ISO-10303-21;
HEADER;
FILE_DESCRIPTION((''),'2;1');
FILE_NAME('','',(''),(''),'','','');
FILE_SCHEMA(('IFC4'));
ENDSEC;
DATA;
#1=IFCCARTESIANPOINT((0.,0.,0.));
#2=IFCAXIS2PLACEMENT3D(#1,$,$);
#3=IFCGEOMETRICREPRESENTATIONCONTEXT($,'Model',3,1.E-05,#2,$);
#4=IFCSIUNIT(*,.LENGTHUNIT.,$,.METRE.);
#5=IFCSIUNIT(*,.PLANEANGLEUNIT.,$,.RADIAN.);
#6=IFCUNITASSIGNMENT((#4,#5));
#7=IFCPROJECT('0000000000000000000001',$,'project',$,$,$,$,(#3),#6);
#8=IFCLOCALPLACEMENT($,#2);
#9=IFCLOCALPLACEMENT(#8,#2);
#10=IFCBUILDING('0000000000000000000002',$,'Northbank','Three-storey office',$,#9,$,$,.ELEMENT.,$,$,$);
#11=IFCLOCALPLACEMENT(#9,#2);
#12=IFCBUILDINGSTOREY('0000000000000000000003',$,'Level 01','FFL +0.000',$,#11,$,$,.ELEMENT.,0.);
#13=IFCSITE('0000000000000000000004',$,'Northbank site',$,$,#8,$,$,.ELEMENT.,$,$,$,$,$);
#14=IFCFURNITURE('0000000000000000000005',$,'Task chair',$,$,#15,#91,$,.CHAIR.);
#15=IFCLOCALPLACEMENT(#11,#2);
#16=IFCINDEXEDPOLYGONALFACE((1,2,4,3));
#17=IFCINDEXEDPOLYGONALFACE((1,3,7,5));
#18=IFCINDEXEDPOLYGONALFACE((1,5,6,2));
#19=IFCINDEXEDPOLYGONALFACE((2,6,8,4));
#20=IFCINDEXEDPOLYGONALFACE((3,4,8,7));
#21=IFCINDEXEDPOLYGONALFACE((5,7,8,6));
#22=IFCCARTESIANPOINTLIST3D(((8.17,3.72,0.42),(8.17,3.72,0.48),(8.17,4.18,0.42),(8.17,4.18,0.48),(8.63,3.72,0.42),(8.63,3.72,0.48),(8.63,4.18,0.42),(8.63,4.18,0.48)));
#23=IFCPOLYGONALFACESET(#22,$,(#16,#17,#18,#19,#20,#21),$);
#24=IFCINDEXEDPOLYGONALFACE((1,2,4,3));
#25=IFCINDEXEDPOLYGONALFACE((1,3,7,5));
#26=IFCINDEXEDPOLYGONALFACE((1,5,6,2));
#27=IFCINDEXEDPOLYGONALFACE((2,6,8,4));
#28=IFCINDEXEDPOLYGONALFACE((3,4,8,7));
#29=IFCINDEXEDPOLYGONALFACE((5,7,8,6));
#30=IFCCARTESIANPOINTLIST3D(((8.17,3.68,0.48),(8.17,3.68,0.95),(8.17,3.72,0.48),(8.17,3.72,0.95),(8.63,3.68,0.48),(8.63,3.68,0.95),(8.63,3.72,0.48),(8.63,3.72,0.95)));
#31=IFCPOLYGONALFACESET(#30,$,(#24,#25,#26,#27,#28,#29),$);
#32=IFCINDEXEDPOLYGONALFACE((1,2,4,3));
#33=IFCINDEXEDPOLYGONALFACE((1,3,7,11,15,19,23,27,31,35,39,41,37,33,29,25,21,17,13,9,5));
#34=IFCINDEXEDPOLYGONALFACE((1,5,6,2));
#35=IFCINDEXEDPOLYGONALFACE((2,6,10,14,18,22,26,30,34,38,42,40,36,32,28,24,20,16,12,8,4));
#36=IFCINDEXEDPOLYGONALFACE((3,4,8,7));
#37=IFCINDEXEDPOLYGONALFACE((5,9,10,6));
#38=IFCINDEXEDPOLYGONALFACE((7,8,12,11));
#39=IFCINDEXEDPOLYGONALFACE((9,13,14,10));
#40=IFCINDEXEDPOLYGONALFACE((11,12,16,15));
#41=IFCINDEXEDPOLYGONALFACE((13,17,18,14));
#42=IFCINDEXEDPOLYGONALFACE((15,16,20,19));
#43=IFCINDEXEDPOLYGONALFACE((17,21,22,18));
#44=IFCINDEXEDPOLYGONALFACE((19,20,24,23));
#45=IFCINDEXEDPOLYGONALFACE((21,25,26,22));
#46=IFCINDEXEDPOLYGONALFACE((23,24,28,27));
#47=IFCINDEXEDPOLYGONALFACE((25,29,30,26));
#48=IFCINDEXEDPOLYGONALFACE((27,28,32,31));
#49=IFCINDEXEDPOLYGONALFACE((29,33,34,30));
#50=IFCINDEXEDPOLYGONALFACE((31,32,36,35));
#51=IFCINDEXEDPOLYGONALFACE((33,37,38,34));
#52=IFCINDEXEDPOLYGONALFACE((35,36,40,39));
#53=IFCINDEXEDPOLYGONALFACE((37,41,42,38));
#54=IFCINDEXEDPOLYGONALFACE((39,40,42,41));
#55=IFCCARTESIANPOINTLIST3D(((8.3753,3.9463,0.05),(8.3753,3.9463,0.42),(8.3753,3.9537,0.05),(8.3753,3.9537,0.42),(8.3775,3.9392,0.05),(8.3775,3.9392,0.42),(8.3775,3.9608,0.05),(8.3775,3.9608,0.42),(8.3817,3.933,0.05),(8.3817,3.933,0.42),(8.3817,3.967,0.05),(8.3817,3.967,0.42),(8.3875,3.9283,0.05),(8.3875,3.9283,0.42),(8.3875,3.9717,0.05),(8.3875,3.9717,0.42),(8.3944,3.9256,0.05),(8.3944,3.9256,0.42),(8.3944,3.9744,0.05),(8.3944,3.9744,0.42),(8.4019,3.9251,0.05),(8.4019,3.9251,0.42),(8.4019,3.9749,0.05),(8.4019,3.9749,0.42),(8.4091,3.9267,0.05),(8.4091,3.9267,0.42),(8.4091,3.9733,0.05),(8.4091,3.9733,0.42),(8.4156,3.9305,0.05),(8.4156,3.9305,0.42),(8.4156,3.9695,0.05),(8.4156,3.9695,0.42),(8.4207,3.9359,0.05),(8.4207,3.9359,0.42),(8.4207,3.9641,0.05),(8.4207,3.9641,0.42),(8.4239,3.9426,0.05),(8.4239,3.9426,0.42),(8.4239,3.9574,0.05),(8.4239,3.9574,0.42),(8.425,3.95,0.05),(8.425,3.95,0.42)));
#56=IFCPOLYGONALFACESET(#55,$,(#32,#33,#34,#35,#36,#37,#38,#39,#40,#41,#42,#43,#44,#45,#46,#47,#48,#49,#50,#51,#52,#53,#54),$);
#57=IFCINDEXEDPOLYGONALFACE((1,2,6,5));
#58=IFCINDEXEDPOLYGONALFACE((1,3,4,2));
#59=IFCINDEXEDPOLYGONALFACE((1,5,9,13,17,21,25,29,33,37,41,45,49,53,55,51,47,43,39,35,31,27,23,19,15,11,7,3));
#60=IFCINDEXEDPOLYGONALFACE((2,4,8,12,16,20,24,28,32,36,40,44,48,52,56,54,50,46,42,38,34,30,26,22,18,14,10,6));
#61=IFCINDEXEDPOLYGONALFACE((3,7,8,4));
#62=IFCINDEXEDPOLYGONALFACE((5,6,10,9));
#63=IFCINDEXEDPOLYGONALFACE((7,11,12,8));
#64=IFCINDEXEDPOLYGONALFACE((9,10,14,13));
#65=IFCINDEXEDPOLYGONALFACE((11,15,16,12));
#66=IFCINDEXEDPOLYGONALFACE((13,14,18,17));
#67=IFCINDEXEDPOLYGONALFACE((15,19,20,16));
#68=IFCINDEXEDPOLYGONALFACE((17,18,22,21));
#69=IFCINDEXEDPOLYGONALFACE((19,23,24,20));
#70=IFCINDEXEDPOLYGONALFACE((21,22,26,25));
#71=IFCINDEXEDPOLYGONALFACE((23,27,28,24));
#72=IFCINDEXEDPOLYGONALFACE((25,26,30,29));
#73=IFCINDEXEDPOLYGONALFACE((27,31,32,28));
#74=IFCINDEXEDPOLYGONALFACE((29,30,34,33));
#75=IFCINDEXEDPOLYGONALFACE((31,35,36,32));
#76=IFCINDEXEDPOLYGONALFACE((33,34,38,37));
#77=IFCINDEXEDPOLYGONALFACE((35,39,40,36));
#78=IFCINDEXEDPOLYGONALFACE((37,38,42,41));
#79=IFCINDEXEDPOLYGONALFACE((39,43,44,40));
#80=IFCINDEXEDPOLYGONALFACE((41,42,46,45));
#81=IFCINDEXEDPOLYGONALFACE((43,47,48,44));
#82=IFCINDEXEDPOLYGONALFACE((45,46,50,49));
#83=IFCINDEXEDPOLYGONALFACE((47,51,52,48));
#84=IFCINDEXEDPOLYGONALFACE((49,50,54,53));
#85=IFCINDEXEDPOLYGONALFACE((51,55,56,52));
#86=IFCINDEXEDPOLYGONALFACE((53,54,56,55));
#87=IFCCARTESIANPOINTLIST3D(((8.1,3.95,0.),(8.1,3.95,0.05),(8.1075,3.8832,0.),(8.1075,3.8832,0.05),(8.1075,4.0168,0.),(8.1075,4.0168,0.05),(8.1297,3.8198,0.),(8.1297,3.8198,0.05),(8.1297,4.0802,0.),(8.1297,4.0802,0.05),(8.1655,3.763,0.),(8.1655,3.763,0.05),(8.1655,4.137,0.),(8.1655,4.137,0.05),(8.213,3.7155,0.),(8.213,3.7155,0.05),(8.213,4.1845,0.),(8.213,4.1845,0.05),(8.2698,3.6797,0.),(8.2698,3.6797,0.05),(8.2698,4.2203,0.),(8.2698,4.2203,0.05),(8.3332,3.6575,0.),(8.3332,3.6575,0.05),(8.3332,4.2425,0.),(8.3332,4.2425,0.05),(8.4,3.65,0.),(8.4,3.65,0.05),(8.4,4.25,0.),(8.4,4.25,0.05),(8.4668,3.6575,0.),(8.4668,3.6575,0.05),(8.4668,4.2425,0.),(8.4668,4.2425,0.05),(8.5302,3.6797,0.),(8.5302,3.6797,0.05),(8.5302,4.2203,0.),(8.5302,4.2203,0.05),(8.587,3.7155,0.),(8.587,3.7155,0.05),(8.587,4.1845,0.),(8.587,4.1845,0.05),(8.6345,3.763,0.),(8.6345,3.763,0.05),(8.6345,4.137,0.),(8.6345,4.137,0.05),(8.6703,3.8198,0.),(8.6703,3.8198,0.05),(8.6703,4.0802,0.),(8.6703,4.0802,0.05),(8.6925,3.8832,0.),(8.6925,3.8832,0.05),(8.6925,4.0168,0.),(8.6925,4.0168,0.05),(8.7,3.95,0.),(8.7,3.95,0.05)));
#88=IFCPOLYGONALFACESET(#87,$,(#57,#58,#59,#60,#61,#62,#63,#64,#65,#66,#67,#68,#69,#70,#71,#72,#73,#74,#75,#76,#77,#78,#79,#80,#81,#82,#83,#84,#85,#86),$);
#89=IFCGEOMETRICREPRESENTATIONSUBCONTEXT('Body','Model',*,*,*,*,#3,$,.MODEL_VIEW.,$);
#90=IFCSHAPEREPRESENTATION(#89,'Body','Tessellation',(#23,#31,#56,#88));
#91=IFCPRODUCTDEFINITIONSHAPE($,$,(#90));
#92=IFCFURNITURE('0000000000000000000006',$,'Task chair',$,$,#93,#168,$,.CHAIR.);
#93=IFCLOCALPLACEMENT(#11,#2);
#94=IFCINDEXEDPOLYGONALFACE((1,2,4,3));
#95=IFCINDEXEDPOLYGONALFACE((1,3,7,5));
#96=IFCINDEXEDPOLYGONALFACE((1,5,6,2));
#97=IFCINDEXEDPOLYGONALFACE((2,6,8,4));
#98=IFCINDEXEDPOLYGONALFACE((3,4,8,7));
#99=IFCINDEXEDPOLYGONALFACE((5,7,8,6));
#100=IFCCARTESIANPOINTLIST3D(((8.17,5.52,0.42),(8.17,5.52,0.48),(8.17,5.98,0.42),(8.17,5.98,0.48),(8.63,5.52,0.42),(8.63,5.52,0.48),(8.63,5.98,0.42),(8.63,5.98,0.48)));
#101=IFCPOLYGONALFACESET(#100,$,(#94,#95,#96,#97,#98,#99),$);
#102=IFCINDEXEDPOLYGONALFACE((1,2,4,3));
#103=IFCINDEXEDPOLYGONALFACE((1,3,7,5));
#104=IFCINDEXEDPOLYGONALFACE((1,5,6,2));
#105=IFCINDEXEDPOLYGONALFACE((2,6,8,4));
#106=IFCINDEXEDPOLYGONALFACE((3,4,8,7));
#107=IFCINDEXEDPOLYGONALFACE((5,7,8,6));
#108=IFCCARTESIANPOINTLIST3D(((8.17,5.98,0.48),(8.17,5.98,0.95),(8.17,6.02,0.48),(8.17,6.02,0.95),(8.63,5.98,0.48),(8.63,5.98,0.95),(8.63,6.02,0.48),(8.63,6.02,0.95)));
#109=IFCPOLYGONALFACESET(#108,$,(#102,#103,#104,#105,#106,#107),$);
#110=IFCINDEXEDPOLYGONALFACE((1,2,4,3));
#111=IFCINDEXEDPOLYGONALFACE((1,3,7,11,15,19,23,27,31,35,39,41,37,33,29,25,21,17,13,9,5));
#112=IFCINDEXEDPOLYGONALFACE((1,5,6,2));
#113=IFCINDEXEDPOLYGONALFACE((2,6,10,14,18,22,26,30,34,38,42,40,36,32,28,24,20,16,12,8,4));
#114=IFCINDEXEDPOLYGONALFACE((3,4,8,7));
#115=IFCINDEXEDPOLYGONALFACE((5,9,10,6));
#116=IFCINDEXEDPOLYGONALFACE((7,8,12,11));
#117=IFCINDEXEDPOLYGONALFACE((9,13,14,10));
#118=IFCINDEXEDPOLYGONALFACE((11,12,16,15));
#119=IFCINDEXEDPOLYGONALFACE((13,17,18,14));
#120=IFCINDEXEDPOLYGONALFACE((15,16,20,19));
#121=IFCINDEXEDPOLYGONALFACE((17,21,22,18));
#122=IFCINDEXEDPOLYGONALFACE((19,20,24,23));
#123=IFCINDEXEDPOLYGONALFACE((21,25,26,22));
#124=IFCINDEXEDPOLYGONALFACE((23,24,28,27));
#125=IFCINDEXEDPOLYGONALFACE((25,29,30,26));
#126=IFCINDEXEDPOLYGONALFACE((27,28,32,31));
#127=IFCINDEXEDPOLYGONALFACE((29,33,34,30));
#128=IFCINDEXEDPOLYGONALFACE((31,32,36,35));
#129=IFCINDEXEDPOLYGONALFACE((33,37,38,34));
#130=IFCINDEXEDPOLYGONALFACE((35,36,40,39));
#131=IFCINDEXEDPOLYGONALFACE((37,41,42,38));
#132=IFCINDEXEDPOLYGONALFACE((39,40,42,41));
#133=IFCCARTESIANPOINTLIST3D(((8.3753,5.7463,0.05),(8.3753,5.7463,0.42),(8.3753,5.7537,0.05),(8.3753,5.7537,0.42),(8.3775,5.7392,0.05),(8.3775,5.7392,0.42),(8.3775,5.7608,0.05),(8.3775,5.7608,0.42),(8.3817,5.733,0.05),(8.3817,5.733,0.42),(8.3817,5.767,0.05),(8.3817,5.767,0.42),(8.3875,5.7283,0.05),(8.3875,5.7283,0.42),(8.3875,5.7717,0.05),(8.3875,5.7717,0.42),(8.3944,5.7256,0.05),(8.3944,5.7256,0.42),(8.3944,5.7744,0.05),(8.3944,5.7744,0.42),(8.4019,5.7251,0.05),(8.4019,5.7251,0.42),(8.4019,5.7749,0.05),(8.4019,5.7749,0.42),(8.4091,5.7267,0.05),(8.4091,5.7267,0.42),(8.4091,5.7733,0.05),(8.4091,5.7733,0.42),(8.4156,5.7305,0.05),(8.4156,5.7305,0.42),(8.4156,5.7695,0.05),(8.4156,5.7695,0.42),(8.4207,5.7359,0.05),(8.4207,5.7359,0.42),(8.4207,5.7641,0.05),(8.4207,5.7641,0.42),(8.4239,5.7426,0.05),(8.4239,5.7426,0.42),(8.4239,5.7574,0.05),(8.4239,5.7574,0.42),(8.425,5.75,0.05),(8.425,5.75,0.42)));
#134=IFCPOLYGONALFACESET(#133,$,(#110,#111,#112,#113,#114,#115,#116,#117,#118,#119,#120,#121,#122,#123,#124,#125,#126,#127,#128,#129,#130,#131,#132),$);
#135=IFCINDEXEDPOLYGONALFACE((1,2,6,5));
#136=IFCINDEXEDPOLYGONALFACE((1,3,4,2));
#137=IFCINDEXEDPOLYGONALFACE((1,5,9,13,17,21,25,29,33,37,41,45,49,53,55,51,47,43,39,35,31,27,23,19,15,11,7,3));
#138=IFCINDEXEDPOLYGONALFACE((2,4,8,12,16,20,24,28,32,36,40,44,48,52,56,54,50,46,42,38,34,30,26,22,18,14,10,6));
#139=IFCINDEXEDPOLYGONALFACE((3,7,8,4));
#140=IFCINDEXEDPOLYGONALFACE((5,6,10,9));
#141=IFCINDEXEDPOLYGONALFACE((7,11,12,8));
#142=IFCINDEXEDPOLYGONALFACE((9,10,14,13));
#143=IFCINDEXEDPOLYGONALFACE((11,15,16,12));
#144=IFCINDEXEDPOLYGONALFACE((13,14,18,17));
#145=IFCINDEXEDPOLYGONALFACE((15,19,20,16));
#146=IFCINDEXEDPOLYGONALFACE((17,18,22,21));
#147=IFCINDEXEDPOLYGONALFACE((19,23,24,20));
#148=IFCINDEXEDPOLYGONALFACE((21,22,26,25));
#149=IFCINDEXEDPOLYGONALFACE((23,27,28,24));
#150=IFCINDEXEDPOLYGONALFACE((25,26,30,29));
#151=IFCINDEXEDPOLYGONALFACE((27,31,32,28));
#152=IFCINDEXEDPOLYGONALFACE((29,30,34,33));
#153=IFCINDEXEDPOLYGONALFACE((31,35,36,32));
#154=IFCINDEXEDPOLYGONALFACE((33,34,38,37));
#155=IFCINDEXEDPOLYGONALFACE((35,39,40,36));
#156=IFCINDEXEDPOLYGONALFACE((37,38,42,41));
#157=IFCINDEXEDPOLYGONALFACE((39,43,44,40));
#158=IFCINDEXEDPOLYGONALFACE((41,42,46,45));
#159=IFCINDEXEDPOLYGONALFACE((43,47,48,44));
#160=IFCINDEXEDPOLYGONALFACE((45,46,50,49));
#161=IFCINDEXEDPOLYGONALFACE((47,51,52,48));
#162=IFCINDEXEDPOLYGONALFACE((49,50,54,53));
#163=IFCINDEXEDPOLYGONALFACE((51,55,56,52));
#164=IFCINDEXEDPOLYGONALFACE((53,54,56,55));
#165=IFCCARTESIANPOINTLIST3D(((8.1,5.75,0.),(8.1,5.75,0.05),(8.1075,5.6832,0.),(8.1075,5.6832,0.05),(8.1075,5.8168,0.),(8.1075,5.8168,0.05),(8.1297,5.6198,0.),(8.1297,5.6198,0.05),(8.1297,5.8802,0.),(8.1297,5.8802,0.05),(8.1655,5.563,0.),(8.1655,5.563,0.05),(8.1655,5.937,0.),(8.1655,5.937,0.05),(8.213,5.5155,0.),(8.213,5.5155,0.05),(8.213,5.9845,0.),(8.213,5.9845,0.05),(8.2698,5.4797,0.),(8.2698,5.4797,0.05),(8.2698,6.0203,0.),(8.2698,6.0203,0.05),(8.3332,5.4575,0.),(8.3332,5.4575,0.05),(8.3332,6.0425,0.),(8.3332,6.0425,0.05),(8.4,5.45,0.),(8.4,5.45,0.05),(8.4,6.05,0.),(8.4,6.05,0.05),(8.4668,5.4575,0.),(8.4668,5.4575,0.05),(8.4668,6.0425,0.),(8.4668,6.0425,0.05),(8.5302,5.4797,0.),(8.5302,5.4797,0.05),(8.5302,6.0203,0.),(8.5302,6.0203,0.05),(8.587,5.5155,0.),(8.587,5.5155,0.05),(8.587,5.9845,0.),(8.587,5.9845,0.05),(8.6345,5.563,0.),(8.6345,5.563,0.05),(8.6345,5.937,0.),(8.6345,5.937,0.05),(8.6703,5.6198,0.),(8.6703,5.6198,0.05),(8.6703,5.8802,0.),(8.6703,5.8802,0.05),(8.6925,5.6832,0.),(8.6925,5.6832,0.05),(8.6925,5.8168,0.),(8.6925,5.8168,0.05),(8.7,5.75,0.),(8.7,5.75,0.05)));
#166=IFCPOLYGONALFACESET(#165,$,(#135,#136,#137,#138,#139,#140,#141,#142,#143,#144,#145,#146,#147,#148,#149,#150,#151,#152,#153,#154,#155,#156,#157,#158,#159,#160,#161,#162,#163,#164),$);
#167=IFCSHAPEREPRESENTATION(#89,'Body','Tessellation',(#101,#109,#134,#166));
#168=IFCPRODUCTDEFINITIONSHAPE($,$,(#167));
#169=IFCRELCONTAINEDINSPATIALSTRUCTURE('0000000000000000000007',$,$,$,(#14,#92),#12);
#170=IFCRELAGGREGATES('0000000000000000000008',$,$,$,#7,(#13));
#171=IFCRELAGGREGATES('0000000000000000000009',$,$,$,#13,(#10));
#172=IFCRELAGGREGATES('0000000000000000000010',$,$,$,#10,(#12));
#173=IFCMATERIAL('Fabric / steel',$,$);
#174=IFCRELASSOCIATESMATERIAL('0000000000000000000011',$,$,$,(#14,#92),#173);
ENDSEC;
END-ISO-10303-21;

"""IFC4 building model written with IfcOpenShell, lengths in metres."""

from ifc_helpers import new_model, si_unit, frame, origin, place, context, subcontext, project, spatial, rectangle, circle, extrude, material, element, save


model = new_model("IFC4")

# Units and contexts
model_context = context("Model", 3, precision=1e-05, world=origin())
body_context = subcontext(model_context, "Body", "Model", "MODEL_VIEW")
ifc_project = project(units=[si_unit("LENGTHUNIT", "METRE"), si_unit("PLANEANGLEUNIT", "RADIAN")], contexts=[model_context])

# Site, building, storey
site_placement = place(None, origin())
site = spatial("IfcSite", under=ifc_project, at=site_placement, Name="Northbank site", CompositionType="ELEMENT")
building_placement = place(site_placement, origin())
building = spatial("IfcBuilding", under=site, at=building_placement, Name="Northbank", Description="Three-storey office", CompositionType="ELEMENT")
storey_placement = place(building_placement, origin())
storey = spatial("IfcBuildingStorey", under=building, at=storey_placement, Name="Level 01", Description="FFL +0.000", CompositionType="ELEMENT", Elevation=0.0)

# Furniture
ifc_material_1 = material(Name="Fabric / steel")
furniture_1_placement = place(storey_placement, origin())
element("IfcFurniture", 1, at=furniture_1_placement, inside=storey, material=ifc_material_1, Name="Task chair", PredefinedType="CHAIR", context=body_context, shape_type="SweptSolid", body=[
    extrude(rectangle(XDim=0.46, YDim=0.46), frame((8.4, 3.95, 0.42)), (0.0, 0.0, 1.0), 0.06),
    extrude(rectangle(XDim=0.46, YDim=0.04), frame((8.4, 3.7, 0.48)), (0.0, 0.0, 1.0), 0.47),
    extrude(circle(Radius=0.025), frame((8.4, 3.95, 0.05), z_axis=(0.0, 0.0, 1.0), x_axis=(1.0, 0.0, 0.0)), (0.0, 0.0, 1.0), 0.37),
    extrude(circle(Radius=0.3), frame((8.4, 3.95, 0.0), z_axis=(0.0, 0.0, 1.0), x_axis=(1.0, 0.0, 0.0)), (0.0, 0.0, 1.0), 0.05),
])
furniture_2_placement = place(storey_placement, origin())
element("IfcFurniture", 2, at=furniture_2_placement, inside=storey, material=ifc_material_1, Name="Task chair", PredefinedType="CHAIR", context=body_context, shape_type="SweptSolid", body=[
    extrude(rectangle(XDim=0.46, YDim=0.46), frame((8.4, 5.75, 0.42)), (0.0, 0.0, 1.0), 0.06),
    extrude(rectangle(XDim=0.46, YDim=0.04), frame((8.4, 6.0, 0.48)), (0.0, 0.0, 1.0), 0.47),
    extrude(circle(Radius=0.025), frame((8.4, 5.75, 0.05), z_axis=(0.0, 0.0, 1.0), x_axis=(1.0, 0.0, 0.0)), (0.0, 0.0, 1.0), 0.37),
    extrude(circle(Radius=0.3), frame((8.4, 5.75, 0.0), z_axis=(0.0, 0.0, 1.0), x_axis=(1.0, 0.0, 0.0)), (0.0, 0.0, 1.0), 0.05),
])

save(model, "model.ifc")
